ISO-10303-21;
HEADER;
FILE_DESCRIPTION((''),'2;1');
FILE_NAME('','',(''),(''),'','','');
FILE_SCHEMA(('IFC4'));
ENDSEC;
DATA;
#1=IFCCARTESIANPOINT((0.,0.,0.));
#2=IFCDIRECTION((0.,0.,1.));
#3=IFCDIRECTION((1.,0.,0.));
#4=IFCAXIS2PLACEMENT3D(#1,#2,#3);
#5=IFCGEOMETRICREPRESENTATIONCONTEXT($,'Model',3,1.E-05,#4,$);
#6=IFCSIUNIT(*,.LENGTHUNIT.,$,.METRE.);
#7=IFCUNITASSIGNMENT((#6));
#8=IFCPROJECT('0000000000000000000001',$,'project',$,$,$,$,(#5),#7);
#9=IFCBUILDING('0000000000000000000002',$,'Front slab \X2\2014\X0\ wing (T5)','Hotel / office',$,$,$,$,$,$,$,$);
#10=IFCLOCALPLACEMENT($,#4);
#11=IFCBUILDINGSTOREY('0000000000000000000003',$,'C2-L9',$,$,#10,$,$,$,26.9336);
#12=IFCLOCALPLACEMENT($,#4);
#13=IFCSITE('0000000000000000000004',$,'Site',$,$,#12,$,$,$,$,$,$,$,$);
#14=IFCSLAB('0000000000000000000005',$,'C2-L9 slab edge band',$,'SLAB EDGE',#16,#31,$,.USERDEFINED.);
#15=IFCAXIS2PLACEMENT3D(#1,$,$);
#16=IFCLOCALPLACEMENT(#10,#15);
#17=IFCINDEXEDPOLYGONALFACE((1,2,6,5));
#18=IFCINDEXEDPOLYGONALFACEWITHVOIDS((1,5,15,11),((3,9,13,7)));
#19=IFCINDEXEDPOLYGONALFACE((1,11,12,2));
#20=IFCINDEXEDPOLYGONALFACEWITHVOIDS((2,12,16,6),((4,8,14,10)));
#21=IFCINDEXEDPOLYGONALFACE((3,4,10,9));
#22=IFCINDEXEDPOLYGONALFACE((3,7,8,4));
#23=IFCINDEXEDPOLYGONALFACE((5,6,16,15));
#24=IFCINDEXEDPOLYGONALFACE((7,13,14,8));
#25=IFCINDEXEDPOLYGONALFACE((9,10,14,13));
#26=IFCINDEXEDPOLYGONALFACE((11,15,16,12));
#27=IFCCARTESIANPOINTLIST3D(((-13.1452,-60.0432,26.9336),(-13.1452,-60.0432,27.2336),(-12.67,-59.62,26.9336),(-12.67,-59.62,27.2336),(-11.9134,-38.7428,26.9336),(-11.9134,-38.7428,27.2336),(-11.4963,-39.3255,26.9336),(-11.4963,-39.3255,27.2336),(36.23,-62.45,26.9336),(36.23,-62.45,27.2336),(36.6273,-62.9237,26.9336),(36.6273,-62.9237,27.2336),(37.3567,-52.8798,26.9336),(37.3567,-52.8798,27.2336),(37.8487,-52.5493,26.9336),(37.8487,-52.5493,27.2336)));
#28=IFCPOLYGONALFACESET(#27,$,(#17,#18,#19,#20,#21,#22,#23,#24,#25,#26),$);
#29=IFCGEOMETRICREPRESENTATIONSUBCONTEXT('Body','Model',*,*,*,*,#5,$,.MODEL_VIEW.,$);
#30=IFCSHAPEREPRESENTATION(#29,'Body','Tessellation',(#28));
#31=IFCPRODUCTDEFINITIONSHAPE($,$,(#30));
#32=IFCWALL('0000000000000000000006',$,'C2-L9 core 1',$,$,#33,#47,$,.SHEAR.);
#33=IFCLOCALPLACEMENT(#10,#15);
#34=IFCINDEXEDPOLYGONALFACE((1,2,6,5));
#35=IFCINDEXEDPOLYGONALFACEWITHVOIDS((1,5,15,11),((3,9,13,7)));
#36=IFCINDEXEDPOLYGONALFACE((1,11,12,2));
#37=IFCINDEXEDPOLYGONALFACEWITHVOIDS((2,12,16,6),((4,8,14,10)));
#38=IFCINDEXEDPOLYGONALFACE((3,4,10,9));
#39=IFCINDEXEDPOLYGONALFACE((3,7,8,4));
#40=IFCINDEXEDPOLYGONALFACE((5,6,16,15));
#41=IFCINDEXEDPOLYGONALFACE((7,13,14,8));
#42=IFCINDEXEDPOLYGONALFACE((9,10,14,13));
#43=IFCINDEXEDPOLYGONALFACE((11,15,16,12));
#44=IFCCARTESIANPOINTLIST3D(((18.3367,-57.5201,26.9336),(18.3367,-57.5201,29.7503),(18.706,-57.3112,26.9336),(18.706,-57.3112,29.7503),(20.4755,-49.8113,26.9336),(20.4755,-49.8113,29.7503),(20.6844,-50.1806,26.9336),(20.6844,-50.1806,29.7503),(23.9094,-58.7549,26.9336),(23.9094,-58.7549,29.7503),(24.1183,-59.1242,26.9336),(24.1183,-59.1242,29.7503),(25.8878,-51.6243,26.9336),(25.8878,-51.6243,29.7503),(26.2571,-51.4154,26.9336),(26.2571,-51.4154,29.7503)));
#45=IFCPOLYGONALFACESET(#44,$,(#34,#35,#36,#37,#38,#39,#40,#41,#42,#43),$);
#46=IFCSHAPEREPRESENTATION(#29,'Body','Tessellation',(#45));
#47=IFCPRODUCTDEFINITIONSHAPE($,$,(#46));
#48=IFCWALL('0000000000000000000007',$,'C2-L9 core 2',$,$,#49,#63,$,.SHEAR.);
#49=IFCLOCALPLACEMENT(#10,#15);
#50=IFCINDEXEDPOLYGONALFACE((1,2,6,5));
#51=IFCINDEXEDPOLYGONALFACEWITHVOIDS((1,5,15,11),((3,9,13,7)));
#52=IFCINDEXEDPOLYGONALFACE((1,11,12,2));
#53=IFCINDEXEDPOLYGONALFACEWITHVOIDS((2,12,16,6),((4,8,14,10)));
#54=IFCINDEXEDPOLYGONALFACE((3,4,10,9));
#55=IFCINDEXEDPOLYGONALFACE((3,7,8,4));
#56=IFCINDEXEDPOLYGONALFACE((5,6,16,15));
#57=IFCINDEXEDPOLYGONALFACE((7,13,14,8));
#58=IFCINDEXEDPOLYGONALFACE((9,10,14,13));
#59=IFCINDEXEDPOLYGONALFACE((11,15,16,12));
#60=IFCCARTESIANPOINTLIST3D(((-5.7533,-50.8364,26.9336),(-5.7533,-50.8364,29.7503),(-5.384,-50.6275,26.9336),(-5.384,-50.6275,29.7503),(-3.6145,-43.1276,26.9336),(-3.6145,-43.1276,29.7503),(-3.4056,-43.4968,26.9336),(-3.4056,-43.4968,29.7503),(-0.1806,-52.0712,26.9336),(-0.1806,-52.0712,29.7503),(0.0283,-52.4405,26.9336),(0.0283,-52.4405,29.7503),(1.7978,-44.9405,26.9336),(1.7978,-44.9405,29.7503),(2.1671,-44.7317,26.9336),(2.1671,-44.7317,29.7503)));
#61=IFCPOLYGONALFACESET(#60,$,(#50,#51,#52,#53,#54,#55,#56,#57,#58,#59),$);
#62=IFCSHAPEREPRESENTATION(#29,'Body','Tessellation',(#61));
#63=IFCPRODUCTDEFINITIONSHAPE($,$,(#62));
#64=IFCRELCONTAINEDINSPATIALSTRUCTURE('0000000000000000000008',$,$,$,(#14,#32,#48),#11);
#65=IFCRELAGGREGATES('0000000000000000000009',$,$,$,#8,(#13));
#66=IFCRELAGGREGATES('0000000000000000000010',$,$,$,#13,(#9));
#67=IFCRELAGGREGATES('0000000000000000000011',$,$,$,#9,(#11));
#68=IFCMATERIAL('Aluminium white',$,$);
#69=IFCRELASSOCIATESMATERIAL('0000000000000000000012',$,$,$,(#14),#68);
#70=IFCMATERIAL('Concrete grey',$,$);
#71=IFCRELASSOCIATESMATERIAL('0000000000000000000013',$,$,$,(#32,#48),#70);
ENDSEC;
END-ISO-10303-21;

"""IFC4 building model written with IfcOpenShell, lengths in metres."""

from ifc_helpers import new_model, si_unit, frame, origin_with_axes, place, context, subcontext, project, spatial, polyline, outline, extrude, material, element, save


model = new_model("IFC4")

# Units and contexts
model_context = context("Model", 3, precision=1e-05, world=origin_with_axes())
body_context = subcontext(model_context, "Body", "Model", "MODEL_VIEW")
ifc_project = project(units=[si_unit("LENGTHUNIT", "METRE")], contexts=[model_context])

# Site, building, storey
site_placement = place(None, origin_with_axes())
site = spatial("IfcSite", under=ifc_project, at=site_placement, Name="Site")
building = spatial("IfcBuilding", under=site, Name="Front slab — wing (T5)", Description="Hotel / office")
storey_placement = place(None, origin_with_axes())
storey = spatial("IfcBuildingStorey", under=building, at=storey_placement, Name="C2-L9", Elevation=26.9336)

# Slab
ifc_material_1 = material(Name="Aluminium white")
slab_placement = place(storey_placement, origin_with_axes())
element("IfcSlab", 1, at=slab_placement, inside=storey, material=ifc_material_1, Name="C2-L9 slab edge band", ObjectType="SLAB EDGE", PredefinedType="USERDEFINED", context=body_context, shape_type="SweptSolid", body=[
    extrude(outline(polyline([(-11.9134, -38.7428), (-13.1452, -60.0432), (36.6273, -62.9237), (37.8487, -52.5493), (-11.9134, -38.7428)]), holes=[polyline([(-11.4963, -39.3255), (-12.67, -59.62), (36.23, -62.45), (37.3567, -52.8798), (-11.4963, -39.3255)])]), frame((0.0, 0.0, 26.9336), z_axis=(0.0, 0.0, 1.0), x_axis=(1.0, 0.0, 0.0)), (0.0, 0.0, 1.0), 0.3),
])

# Walls
ifc_material_2 = material(Name="Concrete grey")
wall_1_placement = place(storey_placement, origin_with_axes())
element("IfcWall", 2, at=wall_1_placement, inside=storey, material=ifc_material_2, Name="C2-L9 core 1", PredefinedType="SHEAR", context=body_context, shape_type="SweptSolid", body=[
    extrude(outline(polyline([(26.2571, -51.4154), (20.4755, -49.8113), (18.3367, -57.5201), (24.1183, -59.1242), (26.2571, -51.4154)]), holes=[polyline([(25.8878, -51.6243), (20.6844, -50.1806), (18.706, -57.3112), (23.9094, -58.7549), (25.8878, -51.6243)])]), frame((0.0, 0.0, 26.9336), z_axis=(0.0, 0.0, 1.0), x_axis=(1.0, 0.0, 0.0)), (0.0, 0.0, 1.0), 2.8167),
])
wall_2_placement = place(storey_placement, origin_with_axes())
element("IfcWall", 3, at=wall_2_placement, inside=storey, material=ifc_material_2, Name="C2-L9 core 2", PredefinedType="SHEAR", context=body_context, shape_type="SweptSolid", body=[
    extrude(outline(polyline([(2.1671, -44.7317), (-3.6145, -43.1276), (-5.7533, -50.8364), (0.0283, -52.4405), (2.1671, -44.7317)]), holes=[polyline([(1.7978, -44.9405), (-3.4056, -43.4968), (-5.384, -50.6275), (-0.1806, -52.0712), (1.7978, -44.9405)])]), frame((0.0, 0.0, 26.9336), z_axis=(0.0, 0.0, 1.0), x_axis=(1.0, 0.0, 0.0)), (0.0, 0.0, 1.0), 2.8167),
])

save(model, "model.ifc")
